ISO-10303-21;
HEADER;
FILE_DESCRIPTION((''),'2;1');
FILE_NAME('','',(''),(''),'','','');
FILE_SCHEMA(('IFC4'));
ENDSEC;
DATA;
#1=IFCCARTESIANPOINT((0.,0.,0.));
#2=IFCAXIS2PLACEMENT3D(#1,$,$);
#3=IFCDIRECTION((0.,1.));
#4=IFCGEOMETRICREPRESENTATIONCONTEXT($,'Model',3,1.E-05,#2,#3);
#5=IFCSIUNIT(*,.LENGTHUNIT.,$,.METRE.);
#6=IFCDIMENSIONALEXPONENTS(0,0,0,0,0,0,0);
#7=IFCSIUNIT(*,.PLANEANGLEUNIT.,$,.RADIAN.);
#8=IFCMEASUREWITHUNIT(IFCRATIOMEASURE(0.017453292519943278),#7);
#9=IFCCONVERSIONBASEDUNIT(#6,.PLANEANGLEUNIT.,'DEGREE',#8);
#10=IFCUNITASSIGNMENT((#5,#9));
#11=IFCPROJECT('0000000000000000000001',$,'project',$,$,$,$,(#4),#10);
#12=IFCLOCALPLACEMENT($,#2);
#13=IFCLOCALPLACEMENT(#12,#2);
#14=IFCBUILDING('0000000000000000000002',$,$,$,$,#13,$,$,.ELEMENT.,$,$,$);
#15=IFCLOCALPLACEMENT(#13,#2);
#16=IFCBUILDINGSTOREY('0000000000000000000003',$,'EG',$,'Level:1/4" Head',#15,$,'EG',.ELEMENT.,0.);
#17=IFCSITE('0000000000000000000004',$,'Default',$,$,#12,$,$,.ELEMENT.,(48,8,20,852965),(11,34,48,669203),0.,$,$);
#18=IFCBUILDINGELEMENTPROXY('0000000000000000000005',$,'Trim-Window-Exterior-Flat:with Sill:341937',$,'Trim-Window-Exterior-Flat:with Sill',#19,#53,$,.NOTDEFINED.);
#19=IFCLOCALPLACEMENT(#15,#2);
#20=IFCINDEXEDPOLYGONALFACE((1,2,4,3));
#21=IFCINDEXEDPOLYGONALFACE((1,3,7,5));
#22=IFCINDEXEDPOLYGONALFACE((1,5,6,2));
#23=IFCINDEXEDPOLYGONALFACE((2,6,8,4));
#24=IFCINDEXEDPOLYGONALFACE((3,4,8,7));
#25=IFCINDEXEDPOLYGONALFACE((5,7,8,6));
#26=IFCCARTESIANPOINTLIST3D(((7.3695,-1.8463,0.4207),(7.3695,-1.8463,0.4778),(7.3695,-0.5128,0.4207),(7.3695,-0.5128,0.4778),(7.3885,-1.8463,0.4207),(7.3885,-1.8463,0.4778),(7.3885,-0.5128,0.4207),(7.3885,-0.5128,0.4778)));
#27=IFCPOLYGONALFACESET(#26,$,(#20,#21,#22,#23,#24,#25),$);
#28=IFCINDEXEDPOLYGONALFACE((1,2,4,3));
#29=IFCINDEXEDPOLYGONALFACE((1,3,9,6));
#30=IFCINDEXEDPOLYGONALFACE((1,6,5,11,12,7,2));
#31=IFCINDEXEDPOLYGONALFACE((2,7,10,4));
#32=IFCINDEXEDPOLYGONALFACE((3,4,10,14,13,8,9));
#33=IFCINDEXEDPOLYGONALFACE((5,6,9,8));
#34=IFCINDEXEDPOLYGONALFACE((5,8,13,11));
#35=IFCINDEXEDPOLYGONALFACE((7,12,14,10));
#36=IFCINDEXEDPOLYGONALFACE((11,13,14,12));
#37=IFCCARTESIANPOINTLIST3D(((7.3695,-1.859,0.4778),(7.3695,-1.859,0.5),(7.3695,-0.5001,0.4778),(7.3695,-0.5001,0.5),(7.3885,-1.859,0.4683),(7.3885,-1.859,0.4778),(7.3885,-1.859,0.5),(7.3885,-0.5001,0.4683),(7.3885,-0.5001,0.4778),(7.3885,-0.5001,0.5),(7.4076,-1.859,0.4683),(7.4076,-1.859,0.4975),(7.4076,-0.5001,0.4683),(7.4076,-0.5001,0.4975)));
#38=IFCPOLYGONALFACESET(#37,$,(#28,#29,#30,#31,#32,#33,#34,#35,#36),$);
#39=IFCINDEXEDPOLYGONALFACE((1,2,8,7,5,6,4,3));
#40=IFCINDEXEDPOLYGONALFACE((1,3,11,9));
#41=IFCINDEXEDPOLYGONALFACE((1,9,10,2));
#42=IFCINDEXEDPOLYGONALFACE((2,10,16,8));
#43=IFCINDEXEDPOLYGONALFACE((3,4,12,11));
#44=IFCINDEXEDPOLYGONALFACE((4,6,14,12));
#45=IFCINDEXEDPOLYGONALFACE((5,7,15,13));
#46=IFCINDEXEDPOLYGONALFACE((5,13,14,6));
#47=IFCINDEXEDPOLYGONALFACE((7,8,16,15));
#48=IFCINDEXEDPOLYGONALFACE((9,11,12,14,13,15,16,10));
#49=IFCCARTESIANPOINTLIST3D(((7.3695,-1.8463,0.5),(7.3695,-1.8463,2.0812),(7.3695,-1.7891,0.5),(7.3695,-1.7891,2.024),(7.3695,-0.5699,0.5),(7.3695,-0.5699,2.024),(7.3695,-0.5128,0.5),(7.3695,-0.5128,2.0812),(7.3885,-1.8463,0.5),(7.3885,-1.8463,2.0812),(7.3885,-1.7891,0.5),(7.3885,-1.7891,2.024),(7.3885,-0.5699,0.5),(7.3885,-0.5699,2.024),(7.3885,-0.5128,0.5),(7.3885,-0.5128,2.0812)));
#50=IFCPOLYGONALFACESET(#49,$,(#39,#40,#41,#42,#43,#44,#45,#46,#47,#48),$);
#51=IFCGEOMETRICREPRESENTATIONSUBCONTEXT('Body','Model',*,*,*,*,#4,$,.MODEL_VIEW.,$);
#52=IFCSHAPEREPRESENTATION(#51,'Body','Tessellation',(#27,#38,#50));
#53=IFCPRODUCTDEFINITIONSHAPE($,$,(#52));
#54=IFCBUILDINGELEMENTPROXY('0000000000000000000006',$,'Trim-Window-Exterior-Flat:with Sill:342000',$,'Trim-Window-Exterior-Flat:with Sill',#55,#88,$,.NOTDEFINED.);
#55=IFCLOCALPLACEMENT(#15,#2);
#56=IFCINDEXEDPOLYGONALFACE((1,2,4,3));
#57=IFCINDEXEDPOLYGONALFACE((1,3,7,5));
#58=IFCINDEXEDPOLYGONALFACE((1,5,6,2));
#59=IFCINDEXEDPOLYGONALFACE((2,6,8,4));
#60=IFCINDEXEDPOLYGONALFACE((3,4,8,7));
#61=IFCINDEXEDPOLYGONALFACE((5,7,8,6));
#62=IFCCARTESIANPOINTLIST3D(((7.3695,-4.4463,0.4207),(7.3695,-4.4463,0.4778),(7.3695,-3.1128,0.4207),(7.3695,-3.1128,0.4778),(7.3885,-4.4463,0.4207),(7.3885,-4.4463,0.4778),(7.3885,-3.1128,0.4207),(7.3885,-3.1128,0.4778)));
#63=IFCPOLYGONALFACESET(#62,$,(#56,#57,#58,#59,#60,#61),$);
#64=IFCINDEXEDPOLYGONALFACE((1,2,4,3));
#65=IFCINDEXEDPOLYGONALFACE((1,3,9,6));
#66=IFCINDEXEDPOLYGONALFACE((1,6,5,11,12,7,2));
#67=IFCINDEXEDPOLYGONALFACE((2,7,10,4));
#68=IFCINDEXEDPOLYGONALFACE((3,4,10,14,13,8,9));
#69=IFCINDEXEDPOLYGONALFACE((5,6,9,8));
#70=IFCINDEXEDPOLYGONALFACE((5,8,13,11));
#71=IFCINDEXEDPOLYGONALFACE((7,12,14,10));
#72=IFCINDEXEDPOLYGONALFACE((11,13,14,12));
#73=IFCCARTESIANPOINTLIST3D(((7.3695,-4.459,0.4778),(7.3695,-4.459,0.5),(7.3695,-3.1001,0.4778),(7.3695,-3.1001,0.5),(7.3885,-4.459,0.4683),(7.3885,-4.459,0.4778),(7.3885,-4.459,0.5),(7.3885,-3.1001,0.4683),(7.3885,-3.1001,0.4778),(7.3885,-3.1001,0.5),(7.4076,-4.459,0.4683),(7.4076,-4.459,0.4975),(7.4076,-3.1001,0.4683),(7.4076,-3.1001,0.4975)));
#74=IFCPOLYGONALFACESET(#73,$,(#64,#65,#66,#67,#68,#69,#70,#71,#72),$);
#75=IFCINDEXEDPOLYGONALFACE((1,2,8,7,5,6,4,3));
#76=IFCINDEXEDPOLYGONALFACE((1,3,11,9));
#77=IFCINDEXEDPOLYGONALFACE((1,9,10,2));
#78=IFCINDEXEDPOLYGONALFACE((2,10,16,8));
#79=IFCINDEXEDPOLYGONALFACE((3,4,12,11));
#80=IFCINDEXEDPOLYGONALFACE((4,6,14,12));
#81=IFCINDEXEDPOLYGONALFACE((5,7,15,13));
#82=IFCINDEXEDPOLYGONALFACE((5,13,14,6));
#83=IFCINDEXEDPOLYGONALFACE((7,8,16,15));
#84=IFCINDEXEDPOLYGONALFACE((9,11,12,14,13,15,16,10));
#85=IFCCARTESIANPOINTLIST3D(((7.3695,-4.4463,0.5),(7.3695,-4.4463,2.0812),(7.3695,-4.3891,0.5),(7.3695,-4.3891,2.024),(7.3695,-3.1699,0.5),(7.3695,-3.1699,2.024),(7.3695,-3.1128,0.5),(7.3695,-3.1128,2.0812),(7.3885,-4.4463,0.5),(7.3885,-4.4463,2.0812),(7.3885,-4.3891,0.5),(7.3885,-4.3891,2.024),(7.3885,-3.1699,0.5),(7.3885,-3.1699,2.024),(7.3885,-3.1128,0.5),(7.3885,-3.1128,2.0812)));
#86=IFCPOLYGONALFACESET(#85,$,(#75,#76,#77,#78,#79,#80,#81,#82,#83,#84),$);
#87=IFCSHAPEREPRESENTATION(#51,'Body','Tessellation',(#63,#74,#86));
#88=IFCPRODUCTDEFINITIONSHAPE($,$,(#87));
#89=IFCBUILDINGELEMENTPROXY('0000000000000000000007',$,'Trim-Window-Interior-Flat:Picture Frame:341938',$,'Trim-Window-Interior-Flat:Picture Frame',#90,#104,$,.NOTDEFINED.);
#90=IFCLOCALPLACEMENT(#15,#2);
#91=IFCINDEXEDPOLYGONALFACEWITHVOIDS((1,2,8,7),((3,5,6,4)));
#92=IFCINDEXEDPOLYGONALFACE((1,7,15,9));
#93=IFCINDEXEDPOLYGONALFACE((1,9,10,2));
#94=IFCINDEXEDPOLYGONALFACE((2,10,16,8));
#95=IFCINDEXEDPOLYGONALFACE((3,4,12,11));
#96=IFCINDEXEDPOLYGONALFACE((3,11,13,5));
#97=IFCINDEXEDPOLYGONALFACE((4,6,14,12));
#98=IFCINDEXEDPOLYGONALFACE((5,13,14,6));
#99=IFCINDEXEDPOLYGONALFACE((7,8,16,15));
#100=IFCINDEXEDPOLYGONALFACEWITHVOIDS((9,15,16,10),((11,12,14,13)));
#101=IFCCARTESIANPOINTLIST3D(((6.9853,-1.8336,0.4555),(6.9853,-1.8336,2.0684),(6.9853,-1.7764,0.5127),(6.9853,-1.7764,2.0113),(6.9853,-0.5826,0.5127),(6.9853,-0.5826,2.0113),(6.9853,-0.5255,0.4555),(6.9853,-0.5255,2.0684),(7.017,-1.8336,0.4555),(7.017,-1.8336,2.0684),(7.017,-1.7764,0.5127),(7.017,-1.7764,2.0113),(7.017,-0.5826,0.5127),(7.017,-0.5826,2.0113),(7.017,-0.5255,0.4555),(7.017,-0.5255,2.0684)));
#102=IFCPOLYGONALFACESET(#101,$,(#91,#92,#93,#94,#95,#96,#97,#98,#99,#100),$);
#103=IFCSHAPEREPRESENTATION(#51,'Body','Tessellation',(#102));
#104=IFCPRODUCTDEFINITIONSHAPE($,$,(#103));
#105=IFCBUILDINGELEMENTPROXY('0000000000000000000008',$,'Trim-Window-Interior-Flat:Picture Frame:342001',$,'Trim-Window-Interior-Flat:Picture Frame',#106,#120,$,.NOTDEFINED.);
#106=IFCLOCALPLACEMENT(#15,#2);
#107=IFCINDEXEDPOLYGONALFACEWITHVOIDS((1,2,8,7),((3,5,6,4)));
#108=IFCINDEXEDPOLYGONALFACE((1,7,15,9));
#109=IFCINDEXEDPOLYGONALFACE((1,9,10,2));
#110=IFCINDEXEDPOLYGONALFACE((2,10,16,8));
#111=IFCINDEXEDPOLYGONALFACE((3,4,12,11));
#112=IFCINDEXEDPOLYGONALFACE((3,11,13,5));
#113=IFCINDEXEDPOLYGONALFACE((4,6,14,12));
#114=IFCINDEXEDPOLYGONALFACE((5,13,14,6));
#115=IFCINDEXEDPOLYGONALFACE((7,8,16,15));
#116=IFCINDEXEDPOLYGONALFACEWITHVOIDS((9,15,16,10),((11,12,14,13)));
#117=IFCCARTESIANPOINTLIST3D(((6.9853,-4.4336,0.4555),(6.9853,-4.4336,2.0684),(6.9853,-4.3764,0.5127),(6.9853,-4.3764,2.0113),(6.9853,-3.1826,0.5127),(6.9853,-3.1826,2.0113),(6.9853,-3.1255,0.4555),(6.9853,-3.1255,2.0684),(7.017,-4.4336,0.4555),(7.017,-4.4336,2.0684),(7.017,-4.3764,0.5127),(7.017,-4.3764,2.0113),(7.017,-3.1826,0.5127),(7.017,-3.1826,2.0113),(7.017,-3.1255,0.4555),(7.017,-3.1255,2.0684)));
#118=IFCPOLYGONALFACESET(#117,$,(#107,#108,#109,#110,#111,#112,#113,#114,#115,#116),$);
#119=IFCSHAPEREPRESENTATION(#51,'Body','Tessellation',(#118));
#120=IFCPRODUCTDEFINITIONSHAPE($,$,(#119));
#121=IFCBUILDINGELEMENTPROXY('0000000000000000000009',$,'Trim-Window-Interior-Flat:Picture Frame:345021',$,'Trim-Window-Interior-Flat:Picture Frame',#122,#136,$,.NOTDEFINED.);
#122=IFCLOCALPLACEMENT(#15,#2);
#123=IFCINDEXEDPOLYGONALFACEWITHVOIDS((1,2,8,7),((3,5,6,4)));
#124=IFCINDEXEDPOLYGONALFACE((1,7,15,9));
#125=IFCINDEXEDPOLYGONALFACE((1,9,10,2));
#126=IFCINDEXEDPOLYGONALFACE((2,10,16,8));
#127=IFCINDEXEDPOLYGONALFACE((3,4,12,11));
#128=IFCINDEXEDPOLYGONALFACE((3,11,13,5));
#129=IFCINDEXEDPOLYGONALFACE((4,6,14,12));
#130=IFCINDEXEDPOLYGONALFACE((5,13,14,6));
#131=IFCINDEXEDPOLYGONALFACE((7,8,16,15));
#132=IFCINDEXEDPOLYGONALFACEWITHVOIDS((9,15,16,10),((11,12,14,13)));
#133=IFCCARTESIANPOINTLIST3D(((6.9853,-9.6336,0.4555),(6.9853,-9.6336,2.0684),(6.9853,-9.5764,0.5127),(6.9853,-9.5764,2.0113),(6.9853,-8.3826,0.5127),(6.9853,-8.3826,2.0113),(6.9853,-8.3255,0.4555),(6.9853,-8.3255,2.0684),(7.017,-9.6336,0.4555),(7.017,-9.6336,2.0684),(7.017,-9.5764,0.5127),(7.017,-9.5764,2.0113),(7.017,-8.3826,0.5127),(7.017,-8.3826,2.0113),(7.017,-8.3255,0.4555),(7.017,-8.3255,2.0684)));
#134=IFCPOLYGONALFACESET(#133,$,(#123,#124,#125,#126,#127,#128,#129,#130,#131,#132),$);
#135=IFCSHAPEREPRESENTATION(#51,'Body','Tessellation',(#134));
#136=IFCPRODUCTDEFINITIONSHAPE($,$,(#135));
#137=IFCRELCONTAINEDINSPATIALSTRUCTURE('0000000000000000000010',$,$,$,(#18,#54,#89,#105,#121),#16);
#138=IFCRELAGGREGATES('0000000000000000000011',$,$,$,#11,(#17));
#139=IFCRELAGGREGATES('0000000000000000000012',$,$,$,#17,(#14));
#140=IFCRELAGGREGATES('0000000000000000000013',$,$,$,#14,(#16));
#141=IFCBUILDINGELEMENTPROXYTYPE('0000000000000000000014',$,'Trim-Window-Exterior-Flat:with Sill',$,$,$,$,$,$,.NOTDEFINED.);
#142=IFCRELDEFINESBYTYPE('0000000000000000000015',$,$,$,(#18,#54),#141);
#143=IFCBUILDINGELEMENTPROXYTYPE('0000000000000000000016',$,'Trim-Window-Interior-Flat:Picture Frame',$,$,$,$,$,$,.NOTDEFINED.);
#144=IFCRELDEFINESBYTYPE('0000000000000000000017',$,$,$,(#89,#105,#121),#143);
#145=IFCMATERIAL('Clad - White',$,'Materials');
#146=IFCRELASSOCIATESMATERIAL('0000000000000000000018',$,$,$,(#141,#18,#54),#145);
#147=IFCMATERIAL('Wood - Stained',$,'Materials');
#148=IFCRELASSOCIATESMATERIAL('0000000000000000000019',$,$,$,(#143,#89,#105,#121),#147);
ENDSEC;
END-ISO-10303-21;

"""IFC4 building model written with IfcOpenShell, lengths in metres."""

from ifc_helpers import new_model, entity, si_unit, converted_unit, direction, frame, origin, place, context, subcontext, project, spatial, indexed_curve, outline, extrude, source, transform, mapped, material, type_object, type_shapes, element, save


model = new_model("IFC4")

# Units and contexts
model_context = context("Model", 3, precision=1e-05, world=origin(), true_north=direction((0.0, 1.0)))
body_context = subcontext(model_context, "Body", "Model", "MODEL_VIEW")
ifc_project = project(units=[si_unit("LENGTHUNIT", "METRE"), converted_unit("PLANEANGLEUNIT", "DEGREE", entity("IfcRatioMeasure", 0.017453292519943278), si_unit("PLANEANGLEUNIT", "RADIAN"), dimensions=[0, 0, 0, 0, 0, 0, 0])], contexts=[model_context])

# Site, building, storey
site_placement = place(None, origin())
site = spatial("IfcSite", under=ifc_project, at=site_placement, Name="Default", CompositionType="ELEMENT", RefLatitude=(48, 8, 20, 852965), RefLongitude=(11, 34, 48, 669203), RefElevation=0.0)
building_placement = place(site_placement, origin())
building = spatial("IfcBuilding", under=site, at=building_placement, CompositionType="ELEMENT")
storey_placement = place(building_placement, origin())
storey = spatial("IfcBuildingStorey", under=building, at=storey_placement, Name="EG", ObjectType="Level:1/4\" Head", LongName="EG", CompositionType="ELEMENT", Elevation=0.0)

# Building element proxies
ifc_material_1 = material(Name="Clad - White", Category="Materials")
ifc_material_2 = material(Name="Wood - Stained", Category="Materials")
building_element_proxy_type_1 = type_object("IfcBuildingElementProxyType", Name="Trim-Window-Exterior-Flat:with Sill", PredefinedType="NOTDEFINED", material=ifc_material_1)
shared_shape_1 = source(origin(), body_context, "Body", "SweptSolid", [
    extrude(outline(indexed_curve([(-0.6667, -0.0286), (0.6667, -0.0286), (0.6667, 0.0286), (-0.6667, 0.0286), (-0.6667, -0.0286)], self_intersect=False)), frame((0.0, -1.5748, 0.0), z_axis=(0.0, 0.0, 1.0), x_axis=(-1.0, 0.0, 0.0)), (0.0, 0.0, 1.0), 0.019),
    extrude(outline(indexed_curve([(-0.019, -0.016), (0.0, -0.016), (0.0, -0.0064), (0.019, -0.0064), (0.019, 0.0158), (0.0, 0.0158), (-0.019, 0.0133), (-0.019, -0.016)], self_intersect=False)), frame((-0.6794, -1.5398, 0.019), z_axis=(1.0, 0.0, 0.0), x_axis=(0.0, 0.0, -1.0)), (0.0, 0.0, 1.0), 1.3589),
    extrude(outline(indexed_curve([(-0.8049, -0.6667), (0.7763, -0.6667), (0.7763, -0.6096), (-0.7477, -0.6096), (-0.7477, 0.6096), (0.7763, 0.6096), (0.7763, 0.6667), (-0.8049, 0.6667), (-0.8049, -0.6667)], self_intersect=False)), frame((0.0, -0.7477, 0.0), z_axis=(0.0, 0.0, 1.0), x_axis=(0.0, -1.0, 0.0)), (0.0, 0.0, 1.0), 0.019),
])
type_shapes(building_element_proxy_type_1, [shared_shape_1])
for number, where, z_axis, x_axis, name in (
    (1, (7.3695, -1.1795, 2.024), (1.0, 0.0, 0.0), (0.0, 1.0, 0.0), "Trim-Window-Exterior-Flat:with Sill:341937"),
    (2, (7.3695, -3.7795, 2.024), (1.0, 0.0, 0.0), (0.0, 1.0, 0.0), "Trim-Window-Exterior-Flat:with Sill:342000"),
):
    element("IfcBuildingElementProxy", number, at=place(storey_placement, frame(where, z_axis=z_axis, x_axis=x_axis)), inside=storey, type_object=building_element_proxy_type_1, material=ifc_material_1, Name=name, ObjectType="Trim-Window-Exterior-Flat:with Sill", PredefinedType="NOTDEFINED", context=body_context, shape_type="MappedRepresentation", body=[
        mapped(shared_shape_1, transform((0.0, 0.0, 0.0), scale=1.0)),
    ])
building_element_proxy_type_2 = type_object("IfcBuildingElementProxyType", Name="Trim-Window-Interior-Flat:Picture Frame", PredefinedType="NOTDEFINED", material=ifc_material_2)
shared_shape_2 = source(origin(), body_context, "Body", "SweptSolid", [
    extrude(outline(indexed_curve([(-0.654, -0.8064), (0.654, -0.8064), (0.654, 0.8064), (-0.654, 0.8064), (-0.654, -0.8064)], self_intersect=False), holes=[indexed_curve([(-0.5969, -0.7493), (-0.5969, 0.7493), (0.5969, 0.7493), (0.5969, -0.7493), (-0.5969, -0.7493)], self_intersect=False)]), frame((0.0, -0.762, 0.0), z_axis=(0.0, 0.0, 1.0), x_axis=(-1.0, 0.0, 0.0)), (0.0, 0.0, 1.0), 0.0317),
])
type_shapes(building_element_proxy_type_2, [shared_shape_2])
for number, where, z_axis, x_axis, name in (
    (3, (7.017, -1.1795, 2.024), (-1.0, 0.0, 0.0), (0.0, -1.0, 0.0), "Trim-Window-Interior-Flat:Picture Frame:341938"),
    (4, (7.017, -3.7795, 2.024), (-1.0, 0.0, 0.0), (0.0, -1.0, 0.0), "Trim-Window-Interior-Flat:Picture Frame:342001"),
    (5, (7.017, -8.9795, 2.024), (-1.0, 0.0, 0.0), (0.0, -1.0, 0.0), "Trim-Window-Interior-Flat:Picture Frame:345021"),
):
    element("IfcBuildingElementProxy", number, at=place(storey_placement, frame(where, z_axis=z_axis, x_axis=x_axis)), inside=storey, type_object=building_element_proxy_type_2, material=ifc_material_2, Name=name, ObjectType="Trim-Window-Interior-Flat:Picture Frame", PredefinedType="NOTDEFINED", context=body_context, shape_type="MappedRepresentation", body=[
        mapped(shared_shape_2, transform((0.0, 0.0, 0.0), scale=1.0)),
    ])

save(model, "model.ifc")
